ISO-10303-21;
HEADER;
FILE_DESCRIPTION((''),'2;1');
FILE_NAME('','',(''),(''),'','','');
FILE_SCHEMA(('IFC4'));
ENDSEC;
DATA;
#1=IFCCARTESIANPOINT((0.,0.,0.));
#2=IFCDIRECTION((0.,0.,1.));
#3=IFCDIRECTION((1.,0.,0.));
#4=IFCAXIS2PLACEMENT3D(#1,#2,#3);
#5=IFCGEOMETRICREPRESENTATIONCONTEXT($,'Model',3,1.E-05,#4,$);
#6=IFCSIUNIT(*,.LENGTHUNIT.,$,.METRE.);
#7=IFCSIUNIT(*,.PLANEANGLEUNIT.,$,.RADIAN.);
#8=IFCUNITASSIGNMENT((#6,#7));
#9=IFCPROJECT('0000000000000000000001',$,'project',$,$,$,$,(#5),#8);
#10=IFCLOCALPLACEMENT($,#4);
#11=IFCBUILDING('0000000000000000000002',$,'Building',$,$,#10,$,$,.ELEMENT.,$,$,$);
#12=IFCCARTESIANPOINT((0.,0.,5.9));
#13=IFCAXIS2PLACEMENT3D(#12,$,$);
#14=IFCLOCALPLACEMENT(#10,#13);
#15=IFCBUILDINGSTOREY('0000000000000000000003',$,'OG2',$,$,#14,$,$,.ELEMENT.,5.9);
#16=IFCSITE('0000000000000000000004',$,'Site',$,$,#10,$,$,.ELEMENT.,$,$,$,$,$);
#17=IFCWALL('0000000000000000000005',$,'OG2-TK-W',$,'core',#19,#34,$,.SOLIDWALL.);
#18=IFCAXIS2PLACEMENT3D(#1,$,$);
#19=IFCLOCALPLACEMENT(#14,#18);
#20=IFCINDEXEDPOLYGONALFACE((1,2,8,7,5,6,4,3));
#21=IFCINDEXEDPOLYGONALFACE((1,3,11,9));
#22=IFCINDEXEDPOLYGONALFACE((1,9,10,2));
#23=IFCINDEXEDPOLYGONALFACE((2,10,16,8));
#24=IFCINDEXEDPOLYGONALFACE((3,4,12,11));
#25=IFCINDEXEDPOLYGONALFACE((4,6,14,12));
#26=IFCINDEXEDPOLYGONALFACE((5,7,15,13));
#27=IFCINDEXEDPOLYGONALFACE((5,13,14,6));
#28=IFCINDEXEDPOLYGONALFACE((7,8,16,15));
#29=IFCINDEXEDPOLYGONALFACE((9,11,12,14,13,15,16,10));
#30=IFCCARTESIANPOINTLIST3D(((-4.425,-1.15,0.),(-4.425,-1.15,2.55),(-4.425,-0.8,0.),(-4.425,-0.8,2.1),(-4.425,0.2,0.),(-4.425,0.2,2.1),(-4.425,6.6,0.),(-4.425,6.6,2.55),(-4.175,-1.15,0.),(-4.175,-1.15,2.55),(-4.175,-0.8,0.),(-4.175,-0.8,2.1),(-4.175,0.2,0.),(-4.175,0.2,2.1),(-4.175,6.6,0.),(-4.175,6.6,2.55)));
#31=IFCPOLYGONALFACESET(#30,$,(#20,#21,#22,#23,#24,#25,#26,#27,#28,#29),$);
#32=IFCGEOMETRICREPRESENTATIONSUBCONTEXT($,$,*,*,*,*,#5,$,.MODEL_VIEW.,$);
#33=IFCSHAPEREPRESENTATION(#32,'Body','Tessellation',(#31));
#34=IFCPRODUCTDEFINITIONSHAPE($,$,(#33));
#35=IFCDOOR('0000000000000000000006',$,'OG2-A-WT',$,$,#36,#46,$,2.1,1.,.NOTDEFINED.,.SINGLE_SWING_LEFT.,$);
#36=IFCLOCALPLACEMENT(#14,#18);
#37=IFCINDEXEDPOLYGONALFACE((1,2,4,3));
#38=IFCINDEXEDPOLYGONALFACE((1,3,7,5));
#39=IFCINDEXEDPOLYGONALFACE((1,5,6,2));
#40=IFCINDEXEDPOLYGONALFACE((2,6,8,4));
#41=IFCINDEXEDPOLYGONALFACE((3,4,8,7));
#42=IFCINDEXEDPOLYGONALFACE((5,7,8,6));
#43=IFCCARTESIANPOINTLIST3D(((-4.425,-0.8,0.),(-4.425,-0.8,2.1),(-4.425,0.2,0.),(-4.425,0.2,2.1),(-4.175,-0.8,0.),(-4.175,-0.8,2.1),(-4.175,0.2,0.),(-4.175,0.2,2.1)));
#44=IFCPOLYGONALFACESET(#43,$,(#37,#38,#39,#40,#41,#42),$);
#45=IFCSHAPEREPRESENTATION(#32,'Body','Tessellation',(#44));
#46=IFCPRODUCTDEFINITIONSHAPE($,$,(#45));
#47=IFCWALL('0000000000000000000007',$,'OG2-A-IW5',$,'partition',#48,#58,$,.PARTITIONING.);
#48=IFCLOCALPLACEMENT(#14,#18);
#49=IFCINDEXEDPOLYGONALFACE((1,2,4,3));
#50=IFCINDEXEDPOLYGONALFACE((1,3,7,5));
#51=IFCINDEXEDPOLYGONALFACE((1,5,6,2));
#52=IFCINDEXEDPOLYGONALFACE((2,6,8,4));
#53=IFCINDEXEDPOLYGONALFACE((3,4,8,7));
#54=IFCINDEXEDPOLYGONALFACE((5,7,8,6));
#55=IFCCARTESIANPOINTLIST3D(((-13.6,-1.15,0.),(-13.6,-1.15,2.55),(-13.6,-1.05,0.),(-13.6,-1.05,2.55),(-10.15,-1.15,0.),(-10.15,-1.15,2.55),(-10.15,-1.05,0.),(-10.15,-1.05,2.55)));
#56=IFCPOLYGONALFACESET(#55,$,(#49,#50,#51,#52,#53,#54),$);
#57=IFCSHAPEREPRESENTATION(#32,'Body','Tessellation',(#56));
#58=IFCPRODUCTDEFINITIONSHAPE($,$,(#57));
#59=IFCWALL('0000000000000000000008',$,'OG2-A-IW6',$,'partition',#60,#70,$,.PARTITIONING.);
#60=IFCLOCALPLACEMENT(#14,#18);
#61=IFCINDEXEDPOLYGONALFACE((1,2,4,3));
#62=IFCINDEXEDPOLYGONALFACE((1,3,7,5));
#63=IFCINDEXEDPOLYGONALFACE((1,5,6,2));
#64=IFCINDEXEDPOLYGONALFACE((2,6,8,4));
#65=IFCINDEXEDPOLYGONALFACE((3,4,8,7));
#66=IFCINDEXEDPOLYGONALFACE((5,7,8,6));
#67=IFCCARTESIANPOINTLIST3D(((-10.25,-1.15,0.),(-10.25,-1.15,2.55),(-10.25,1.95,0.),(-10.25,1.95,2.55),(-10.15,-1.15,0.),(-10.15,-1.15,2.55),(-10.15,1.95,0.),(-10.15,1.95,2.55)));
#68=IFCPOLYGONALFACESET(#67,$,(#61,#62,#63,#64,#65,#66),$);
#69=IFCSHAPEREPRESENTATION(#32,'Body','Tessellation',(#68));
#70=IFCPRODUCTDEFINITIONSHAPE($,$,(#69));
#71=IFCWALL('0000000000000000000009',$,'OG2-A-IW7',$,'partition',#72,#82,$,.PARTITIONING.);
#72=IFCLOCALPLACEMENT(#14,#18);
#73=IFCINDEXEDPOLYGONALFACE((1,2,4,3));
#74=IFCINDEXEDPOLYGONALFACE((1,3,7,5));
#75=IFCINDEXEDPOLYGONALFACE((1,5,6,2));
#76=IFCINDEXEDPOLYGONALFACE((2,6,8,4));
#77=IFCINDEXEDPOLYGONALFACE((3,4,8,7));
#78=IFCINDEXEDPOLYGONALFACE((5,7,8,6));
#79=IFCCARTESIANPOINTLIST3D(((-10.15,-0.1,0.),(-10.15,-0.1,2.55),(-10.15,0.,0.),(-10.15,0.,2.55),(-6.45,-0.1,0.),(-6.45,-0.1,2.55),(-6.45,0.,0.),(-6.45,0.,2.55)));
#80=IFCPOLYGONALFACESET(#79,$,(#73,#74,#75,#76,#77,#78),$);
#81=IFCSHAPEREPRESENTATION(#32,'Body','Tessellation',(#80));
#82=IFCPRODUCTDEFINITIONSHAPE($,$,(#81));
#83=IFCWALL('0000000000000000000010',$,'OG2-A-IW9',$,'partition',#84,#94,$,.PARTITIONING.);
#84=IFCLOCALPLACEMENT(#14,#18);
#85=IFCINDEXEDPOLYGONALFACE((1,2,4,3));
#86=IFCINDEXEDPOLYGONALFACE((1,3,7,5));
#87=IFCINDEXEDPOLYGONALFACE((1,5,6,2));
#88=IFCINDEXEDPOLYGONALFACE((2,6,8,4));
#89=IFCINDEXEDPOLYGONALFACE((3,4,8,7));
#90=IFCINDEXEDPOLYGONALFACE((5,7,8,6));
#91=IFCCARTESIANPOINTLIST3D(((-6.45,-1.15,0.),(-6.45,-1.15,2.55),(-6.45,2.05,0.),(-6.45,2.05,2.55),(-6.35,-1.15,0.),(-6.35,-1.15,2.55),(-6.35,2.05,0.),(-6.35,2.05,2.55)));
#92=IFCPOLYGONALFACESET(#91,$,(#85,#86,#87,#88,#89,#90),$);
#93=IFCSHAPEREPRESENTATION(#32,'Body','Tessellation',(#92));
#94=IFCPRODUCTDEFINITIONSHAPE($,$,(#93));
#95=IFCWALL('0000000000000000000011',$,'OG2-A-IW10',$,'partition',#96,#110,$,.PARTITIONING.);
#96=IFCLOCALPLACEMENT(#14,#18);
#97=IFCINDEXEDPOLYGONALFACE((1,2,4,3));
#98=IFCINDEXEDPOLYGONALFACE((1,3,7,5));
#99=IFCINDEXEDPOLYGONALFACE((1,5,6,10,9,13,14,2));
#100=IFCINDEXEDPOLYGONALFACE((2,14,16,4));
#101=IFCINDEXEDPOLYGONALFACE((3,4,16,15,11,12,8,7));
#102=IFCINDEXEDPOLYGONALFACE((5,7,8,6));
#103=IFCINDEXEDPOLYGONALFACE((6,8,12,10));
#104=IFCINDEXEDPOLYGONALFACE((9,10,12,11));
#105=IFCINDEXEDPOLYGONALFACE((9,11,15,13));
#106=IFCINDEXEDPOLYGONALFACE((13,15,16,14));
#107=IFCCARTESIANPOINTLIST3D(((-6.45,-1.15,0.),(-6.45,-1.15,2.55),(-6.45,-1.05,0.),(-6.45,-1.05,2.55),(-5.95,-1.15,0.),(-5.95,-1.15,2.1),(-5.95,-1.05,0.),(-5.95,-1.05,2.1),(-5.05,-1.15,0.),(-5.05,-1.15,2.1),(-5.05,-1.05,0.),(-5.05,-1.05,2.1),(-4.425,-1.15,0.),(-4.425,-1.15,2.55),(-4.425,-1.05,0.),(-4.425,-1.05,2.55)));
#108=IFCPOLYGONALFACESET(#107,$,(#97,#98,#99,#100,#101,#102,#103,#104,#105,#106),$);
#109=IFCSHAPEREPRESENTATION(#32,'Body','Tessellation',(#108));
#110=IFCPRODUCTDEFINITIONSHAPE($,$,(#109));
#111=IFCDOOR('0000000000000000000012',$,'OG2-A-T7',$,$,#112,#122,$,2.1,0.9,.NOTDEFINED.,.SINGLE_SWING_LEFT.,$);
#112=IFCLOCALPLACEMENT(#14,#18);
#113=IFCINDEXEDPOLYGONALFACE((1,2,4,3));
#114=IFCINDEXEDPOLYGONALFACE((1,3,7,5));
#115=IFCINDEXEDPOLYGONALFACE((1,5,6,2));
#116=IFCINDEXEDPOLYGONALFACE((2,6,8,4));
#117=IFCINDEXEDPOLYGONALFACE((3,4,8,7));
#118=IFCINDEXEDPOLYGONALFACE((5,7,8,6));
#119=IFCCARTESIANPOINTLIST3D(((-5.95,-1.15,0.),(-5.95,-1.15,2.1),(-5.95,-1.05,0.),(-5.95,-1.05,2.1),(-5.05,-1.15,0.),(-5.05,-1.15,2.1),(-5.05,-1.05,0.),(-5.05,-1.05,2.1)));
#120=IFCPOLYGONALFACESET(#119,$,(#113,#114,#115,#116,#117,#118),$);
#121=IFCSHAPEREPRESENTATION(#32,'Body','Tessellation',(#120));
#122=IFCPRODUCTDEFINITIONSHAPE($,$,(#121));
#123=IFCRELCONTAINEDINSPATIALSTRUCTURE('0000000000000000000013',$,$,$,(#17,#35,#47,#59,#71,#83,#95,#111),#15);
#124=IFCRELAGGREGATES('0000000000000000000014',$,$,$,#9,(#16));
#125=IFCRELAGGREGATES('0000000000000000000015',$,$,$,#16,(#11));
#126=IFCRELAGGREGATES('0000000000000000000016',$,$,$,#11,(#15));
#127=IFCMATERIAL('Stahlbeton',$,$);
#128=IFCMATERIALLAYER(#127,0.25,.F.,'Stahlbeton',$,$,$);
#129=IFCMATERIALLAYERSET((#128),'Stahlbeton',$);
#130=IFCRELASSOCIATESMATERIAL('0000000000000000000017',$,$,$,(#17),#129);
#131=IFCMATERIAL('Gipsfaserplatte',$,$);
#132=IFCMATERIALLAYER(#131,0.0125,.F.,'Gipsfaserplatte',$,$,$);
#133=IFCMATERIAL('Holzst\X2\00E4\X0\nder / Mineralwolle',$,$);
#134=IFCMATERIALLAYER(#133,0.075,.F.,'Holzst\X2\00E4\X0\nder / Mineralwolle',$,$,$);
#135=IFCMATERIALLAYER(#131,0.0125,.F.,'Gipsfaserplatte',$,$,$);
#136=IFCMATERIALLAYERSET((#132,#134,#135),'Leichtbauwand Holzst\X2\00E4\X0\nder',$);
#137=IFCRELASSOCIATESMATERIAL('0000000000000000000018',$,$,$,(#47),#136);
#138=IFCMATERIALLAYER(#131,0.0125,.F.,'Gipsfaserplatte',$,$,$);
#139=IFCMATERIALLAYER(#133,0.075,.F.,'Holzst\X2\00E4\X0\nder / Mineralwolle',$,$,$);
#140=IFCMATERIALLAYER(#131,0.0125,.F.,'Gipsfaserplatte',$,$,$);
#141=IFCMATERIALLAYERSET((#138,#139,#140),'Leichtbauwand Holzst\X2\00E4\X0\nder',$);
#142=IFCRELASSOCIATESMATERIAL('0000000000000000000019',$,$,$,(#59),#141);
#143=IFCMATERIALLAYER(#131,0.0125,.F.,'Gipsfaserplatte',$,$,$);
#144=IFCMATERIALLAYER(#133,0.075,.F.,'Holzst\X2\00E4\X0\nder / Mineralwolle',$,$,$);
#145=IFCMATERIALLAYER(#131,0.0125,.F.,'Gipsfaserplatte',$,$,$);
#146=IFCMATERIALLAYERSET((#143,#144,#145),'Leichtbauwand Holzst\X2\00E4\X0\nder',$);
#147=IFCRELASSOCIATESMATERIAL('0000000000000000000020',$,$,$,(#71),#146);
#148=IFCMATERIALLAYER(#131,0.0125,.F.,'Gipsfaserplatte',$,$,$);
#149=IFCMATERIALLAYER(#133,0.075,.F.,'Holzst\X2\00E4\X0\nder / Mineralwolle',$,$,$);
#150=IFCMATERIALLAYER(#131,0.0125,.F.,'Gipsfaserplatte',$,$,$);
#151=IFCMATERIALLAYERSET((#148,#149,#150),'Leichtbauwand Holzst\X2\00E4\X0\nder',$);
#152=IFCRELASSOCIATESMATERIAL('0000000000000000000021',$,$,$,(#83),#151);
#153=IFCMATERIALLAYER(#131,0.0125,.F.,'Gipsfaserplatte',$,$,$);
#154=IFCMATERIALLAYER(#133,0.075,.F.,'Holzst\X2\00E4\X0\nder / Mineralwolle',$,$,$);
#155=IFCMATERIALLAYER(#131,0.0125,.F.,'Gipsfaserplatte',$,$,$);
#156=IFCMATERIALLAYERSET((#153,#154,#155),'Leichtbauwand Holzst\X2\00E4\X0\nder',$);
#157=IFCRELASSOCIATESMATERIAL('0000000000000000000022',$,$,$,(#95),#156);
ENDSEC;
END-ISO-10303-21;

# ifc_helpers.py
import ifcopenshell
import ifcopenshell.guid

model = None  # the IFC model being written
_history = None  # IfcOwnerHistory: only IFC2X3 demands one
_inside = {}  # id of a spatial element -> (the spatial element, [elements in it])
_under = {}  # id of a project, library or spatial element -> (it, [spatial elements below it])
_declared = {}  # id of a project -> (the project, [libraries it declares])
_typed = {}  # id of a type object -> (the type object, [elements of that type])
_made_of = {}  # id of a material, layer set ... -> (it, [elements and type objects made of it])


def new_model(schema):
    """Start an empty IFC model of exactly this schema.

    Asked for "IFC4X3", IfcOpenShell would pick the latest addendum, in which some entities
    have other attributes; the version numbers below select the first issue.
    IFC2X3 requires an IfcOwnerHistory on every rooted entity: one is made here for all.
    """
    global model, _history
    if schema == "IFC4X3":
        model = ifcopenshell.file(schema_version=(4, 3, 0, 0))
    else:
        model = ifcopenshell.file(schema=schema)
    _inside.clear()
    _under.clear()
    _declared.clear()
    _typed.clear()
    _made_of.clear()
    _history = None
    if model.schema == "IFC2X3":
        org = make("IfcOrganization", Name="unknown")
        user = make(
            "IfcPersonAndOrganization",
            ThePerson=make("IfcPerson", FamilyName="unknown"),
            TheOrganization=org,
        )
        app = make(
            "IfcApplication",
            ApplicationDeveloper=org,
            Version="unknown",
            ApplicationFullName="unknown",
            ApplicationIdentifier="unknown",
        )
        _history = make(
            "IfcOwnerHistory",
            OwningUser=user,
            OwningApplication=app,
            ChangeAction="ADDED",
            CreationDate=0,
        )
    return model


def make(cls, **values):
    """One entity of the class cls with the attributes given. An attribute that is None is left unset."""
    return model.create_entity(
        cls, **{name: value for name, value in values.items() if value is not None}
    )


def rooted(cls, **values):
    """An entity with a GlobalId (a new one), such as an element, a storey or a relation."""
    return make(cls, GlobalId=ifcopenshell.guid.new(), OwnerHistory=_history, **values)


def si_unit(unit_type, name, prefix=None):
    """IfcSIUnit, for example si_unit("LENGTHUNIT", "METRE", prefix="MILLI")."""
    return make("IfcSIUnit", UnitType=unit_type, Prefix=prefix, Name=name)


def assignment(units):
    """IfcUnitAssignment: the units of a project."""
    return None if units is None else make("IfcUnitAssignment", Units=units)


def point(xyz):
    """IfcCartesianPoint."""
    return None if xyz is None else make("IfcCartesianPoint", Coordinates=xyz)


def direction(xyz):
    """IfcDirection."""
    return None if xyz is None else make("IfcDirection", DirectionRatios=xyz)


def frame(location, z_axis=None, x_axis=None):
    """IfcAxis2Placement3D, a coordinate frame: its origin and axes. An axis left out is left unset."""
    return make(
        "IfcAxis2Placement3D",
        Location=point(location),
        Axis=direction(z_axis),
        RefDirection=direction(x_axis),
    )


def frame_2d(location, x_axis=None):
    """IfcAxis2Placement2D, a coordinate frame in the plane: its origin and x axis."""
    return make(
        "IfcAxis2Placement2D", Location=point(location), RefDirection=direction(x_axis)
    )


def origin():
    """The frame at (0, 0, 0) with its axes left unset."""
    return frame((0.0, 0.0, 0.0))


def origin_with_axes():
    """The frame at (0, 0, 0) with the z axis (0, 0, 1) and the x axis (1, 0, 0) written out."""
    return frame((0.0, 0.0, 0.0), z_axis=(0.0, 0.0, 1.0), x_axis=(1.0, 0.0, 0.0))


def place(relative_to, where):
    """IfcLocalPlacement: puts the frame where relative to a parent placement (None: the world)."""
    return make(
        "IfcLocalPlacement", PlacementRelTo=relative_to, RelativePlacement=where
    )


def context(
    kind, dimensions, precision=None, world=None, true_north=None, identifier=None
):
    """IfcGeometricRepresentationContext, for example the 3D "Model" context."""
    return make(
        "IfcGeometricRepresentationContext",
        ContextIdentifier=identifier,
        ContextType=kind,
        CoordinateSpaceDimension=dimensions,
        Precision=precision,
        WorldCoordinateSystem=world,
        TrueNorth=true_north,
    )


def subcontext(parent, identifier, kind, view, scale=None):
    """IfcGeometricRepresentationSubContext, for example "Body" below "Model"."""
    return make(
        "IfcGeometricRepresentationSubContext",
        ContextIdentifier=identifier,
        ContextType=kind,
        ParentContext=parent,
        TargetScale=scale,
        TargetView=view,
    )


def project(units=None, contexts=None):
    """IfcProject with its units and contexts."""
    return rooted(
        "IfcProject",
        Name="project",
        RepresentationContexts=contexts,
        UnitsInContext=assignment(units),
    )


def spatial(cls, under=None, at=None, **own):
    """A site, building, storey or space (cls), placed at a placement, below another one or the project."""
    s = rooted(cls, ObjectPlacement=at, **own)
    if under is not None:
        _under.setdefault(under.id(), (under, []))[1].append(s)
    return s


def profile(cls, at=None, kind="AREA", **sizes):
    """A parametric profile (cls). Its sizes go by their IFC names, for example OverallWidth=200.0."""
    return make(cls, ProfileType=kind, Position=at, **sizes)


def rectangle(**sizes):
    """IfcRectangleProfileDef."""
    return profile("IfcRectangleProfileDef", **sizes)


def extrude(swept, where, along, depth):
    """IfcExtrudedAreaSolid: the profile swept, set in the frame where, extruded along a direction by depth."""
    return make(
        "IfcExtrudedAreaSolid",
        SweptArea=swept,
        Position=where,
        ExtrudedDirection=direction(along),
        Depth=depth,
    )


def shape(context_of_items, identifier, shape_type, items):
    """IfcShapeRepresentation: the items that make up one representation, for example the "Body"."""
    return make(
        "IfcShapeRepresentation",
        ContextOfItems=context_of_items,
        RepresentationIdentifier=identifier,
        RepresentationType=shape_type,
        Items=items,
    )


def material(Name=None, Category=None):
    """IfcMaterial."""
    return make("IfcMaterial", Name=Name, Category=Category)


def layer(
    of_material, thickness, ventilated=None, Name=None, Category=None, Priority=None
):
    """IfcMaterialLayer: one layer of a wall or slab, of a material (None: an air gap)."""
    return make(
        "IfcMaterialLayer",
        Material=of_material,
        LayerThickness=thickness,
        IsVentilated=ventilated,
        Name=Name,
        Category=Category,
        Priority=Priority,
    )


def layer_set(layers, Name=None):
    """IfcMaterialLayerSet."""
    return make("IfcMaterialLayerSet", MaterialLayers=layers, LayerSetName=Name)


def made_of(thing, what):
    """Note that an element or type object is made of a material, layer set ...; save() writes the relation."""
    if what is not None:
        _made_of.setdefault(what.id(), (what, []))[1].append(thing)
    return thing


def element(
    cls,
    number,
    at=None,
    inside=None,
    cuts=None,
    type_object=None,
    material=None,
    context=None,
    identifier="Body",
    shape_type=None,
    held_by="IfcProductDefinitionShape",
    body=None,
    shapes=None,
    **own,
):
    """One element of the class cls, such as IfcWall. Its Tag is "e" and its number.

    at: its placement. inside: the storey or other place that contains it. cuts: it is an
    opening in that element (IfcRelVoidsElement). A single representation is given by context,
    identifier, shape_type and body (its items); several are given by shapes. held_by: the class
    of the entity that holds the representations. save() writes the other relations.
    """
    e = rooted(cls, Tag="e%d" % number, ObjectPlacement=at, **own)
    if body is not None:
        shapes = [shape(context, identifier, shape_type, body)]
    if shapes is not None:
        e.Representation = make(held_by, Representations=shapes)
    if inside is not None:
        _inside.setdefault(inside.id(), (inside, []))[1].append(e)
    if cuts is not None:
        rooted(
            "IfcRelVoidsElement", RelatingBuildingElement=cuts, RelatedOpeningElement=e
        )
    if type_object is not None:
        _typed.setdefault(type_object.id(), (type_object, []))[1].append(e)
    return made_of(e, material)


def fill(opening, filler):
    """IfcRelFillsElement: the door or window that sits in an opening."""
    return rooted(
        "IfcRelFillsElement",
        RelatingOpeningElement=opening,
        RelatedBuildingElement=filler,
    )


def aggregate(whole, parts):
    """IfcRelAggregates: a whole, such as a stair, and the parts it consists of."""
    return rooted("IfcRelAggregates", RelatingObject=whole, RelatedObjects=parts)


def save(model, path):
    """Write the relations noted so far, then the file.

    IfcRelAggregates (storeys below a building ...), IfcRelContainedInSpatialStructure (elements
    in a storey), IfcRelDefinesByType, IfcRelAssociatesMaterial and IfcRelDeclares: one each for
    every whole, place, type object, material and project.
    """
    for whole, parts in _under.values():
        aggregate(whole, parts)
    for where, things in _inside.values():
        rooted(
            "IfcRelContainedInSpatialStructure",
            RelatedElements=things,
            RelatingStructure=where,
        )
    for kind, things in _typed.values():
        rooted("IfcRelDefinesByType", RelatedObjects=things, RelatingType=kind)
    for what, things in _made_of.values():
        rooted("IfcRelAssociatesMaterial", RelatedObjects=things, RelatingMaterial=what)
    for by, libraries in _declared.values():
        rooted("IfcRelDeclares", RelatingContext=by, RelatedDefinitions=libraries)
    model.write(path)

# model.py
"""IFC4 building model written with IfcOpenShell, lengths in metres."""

from ifc_helpers import new_model, si_unit, frame, frame_2d, origin, origin_with_axes, place, context, subcontext, project, spatial, rectangle, extrude, material, layer, layer_set, element, fill, save


model = new_model("IFC4")

# Units and contexts
model_context = context("Model", 3, precision=1e-05, world=origin_with_axes())
sub_context = subcontext(model_context, None, None, "MODEL_VIEW")
ifc_project = project(units=[si_unit("LENGTHUNIT", "METRE"), si_unit("PLANEANGLEUNIT", "RADIAN")], contexts=[model_context])

# Site, building, storey
placement = place(None, origin_with_axes())
site = spatial("IfcSite", under=ifc_project, at=placement, Name="Site", CompositionType="ELEMENT")
building = spatial("IfcBuilding", under=site, at=placement, Name="Building", CompositionType="ELEMENT")
storey_placement = place(placement, frame((0.0, 0.0, 5.9)))
storey = spatial("IfcBuildingStorey", under=building, at=storey_placement, Name="OG2", CompositionType="ELEMENT", Elevation=5.9)

# Shared definitions
ifc_material_1 = material(Name="Gipsfaserplatte")

# Wall, opening, door
ifc_material_2 = material(Name="Stahlbeton")
ifc_layer_1 = layer(ifc_material_2, 0.25, ventilated=False, Name="Stahlbeton")
ifc_layer_set_1 = layer_set([ifc_layer_1], Name="Stahlbeton")
wall_1_placement = place(storey_placement, frame((-4.3, -1.15, 0.0), z_axis=(0.0, 0.0, 1.0), x_axis=(0.0, 1.0, 0.0)))
wall_1 = element("IfcWall", 1, at=wall_1_placement, inside=storey, material=ifc_layer_set_1, Name="OG2-TK-W", ObjectType="core", PredefinedType="SOLIDWALL", context=sub_context, shape_type="SweptSolid", body=[
    extrude(rectangle(XDim=7.75, YDim=0.25, at=frame_2d((3.875, 0.0))), origin(), (0.0, 0.0, 1.0), 2.55),
])
opening_1_placement = place(wall_1_placement, frame((0.85, 0.175, 0.0), z_axis=(0.0, -1.0, 0.0), x_axis=(1.0, 0.0, 0.0)))
opening_1 = element("IfcOpeningElement", 2, at=opening_1_placement, cuts=wall_1, PredefinedType="OPENING", context=sub_context, shape_type="SweptSolid", body=[
    extrude(rectangle(XDim=1.0, YDim=2.1, at=frame_2d((0.0, 1.05))), origin(), (0.0, 0.0, 1.0), 0.35),
])
door_1_placement = place(wall_1_placement, frame((0.85, 0.125, 0.0), z_axis=(0.0, -1.0, 0.0), x_axis=(1.0, 0.0, 0.0)))
door_1 = element("IfcDoor", 3, at=door_1_placement, inside=storey, Name="OG2-A-WT", OperationType="SINGLE_SWING_LEFT", OverallHeight=2.1, OverallWidth=1.0, PredefinedType="NOTDEFINED", context=sub_context, shape_type="SweptSolid", body=[
    extrude(rectangle(XDim=1.0, YDim=2.1, at=frame_2d((0.0, 1.05))), origin(), (0.0, 0.0, 1.0), 0.25),
])
fill(opening_1, door_1)

# Walls
ifc_layer_2 = layer(ifc_material_1, 0.0125, ventilated=False, Name="Gipsfaserplatte")
ifc_material_3 = material(Name="Holzständer / Mineralwolle")
ifc_layer_3 = layer(ifc_material_3, 0.075, ventilated=False, Name="Holzständer / Mineralwolle")
ifc_layer_4 = layer(ifc_material_1, 0.0125, ventilated=False, Name="Gipsfaserplatte")
ifc_layer_set_2 = layer_set([ifc_layer_2, ifc_layer_3, ifc_layer_4], Name="Leichtbauwand Holzständer")
wall_2_placement = place(storey_placement, frame((-13.6, -1.1, 0.0), z_axis=(0.0, 0.0, 1.0), x_axis=(1.0, 0.0, 0.0)))
element("IfcWall", 4, at=wall_2_placement, inside=storey, material=ifc_layer_set_2, Name="OG2-A-IW5", ObjectType="partition", PredefinedType="PARTITIONING", context=sub_context, shape_type="SweptSolid", body=[
    extrude(rectangle(XDim=3.45, YDim=0.1, at=frame_2d((1.725, 0.0))), origin(), (0.0, 0.0, 1.0), 2.55),
])
ifc_layer_5 = layer(ifc_material_1, 0.0125, ventilated=False, Name="Gipsfaserplatte")
ifc_layer_6 = layer(ifc_material_3, 0.075, ventilated=False, Name="Holzständer / Mineralwolle")
ifc_layer_7 = layer(ifc_material_1, 0.0125, ventilated=False, Name="Gipsfaserplatte")
ifc_layer_set_3 = layer_set([ifc_layer_5, ifc_layer_6, ifc_layer_7], Name="Leichtbauwand Holzständer")
wall_3_placement = place(storey_placement, frame((-10.2, -1.15, 0.0), z_axis=(0.0, 0.0, 1.0), x_axis=(0.0, 1.0, 0.0)))
element("IfcWall", 5, at=wall_3_placement, inside=storey, material=ifc_layer_set_3, Name="OG2-A-IW6", ObjectType="partition", PredefinedType="PARTITIONING", context=sub_context, shape_type="SweptSolid", body=[
    extrude(rectangle(XDim=3.1, YDim=0.1, at=frame_2d((1.55, 0.0))), origin(), (0.0, 0.0, 1.0), 2.55),
])
ifc_layer_8 = layer(ifc_material_1, 0.0125, ventilated=False, Name="Gipsfaserplatte")
ifc_layer_9 = layer(ifc_material_3, 0.075, ventilated=False, Name="Holzständer / Mineralwolle")
ifc_layer_10 = layer(ifc_material_1, 0.0125, ventilated=False, Name="Gipsfaserplatte")
ifc_layer_set_4 = layer_set([ifc_layer_8, ifc_layer_9, ifc_layer_10], Name="Leichtbauwand Holzständer")
wall_4_placement = place(storey_placement, frame((-10.15, -0.05, 0.0), z_axis=(0.0, 0.0, 1.0), x_axis=(1.0, 0.0, 0.0)))
element("IfcWall", 6, at=wall_4_placement, inside=storey, material=ifc_layer_set_4, Name="OG2-A-IW7", ObjectType="partition", PredefinedType="PARTITIONING", context=sub_context, shape_type="SweptSolid", body=[
    extrude(rectangle(XDim=3.7, YDim=0.1, at=frame_2d((1.85, 0.0))), origin(), (0.0, 0.0, 1.0), 2.55),
])
ifc_layer_11 = layer(ifc_material_1, 0.0125, ventilated=False, Name="Gipsfaserplatte")
ifc_layer_12 = layer(ifc_material_3, 0.075, ventilated=False, Name="Holzständer / Mineralwolle")
ifc_layer_13 = layer(ifc_material_1, 0.0125, ventilated=False, Name="Gipsfaserplatte")
ifc_layer_set_5 = layer_set([ifc_layer_11, ifc_layer_12, ifc_layer_13], Name="Leichtbauwand Holzständer")
wall_5_placement = place(storey_placement, frame((-6.4, -1.15, 0.0), z_axis=(0.0, 0.0, 1.0), x_axis=(0.0, 1.0, 0.0)))
element("IfcWall", 7, at=wall_5_placement, inside=storey, material=ifc_layer_set_5, Name="OG2-A-IW9", ObjectType="partition", PredefinedType="PARTITIONING", context=sub_context, shape_type="SweptSolid", body=[
    extrude(rectangle(XDim=3.2, YDim=0.1, at=frame_2d((1.6, 0.0))), origin(), (0.0, 0.0, 1.0), 2.55),
])

# Wall, opening, door
ifc_layer_14 = layer(ifc_material_1, 0.0125, ventilated=False, Name="Gipsfaserplatte")
ifc_layer_15 = layer(ifc_material_3, 0.075, ventilated=False, Name="Holzständer / Mineralwolle")
ifc_layer_16 = layer(ifc_material_1, 0.0125, ventilated=False, Name="Gipsfaserplatte")
ifc_layer_set_6 = layer_set([ifc_layer_14, ifc_layer_15, ifc_layer_16], Name="Leichtbauwand Holzständer")
wall_6_placement = place(storey_placement, frame((-6.45, -1.1, 0.0), z_axis=(0.0, 0.0, 1.0), x_axis=(1.0, 0.0, 0.0)))
wall_6 = element("IfcWall", 8, at=wall_6_placement, inside=storey, material=ifc_layer_set_6, Name="OG2-A-IW10", ObjectType="partition", PredefinedType="PARTITIONING", context=sub_context, shape_type="SweptSolid", body=[
    extrude(rectangle(XDim=2.025, YDim=0.1, at=frame_2d((1.0125, 0.0))), origin(), (0.0, 0.0, 1.0), 2.55),
])
opening_2_placement = place(wall_6_placement, frame((0.95, 0.1, 0.0), z_axis=(0.0, -1.0, 0.0), x_axis=(1.0, 0.0, 0.0)))
opening_2 = element("IfcOpeningElement", 9, at=opening_2_placement, cuts=wall_6, PredefinedType="OPENING", context=sub_context, shape_type="SweptSolid", body=[
    extrude(rectangle(XDim=0.9, YDim=2.1, at=frame_2d((0.0, 1.05))), origin(), (0.0, 0.0, 1.0), 0.2),
])
door_2_placement = place(wall_6_placement, frame((0.95, 0.05, 0.0), z_axis=(0.0, -1.0, 0.0), x_axis=(1.0, 0.0, 0.0)))
door_2 = element("IfcDoor", 10, at=door_2_placement, inside=storey, Name="OG2-A-T7", OperationType="SINGLE_SWING_LEFT", OverallHeight=2.1, OverallWidth=0.9, PredefinedType="NOTDEFINED", context=sub_context, shape_type="SweptSolid", body=[
    extrude(rectangle(XDim=0.9, YDim=2.1, at=frame_2d((0.0, 1.05))), origin(), (0.0, 0.0, 1.0), 0.1),
])
fill(opening_2, door_2)

save(model, "model.ifc")
